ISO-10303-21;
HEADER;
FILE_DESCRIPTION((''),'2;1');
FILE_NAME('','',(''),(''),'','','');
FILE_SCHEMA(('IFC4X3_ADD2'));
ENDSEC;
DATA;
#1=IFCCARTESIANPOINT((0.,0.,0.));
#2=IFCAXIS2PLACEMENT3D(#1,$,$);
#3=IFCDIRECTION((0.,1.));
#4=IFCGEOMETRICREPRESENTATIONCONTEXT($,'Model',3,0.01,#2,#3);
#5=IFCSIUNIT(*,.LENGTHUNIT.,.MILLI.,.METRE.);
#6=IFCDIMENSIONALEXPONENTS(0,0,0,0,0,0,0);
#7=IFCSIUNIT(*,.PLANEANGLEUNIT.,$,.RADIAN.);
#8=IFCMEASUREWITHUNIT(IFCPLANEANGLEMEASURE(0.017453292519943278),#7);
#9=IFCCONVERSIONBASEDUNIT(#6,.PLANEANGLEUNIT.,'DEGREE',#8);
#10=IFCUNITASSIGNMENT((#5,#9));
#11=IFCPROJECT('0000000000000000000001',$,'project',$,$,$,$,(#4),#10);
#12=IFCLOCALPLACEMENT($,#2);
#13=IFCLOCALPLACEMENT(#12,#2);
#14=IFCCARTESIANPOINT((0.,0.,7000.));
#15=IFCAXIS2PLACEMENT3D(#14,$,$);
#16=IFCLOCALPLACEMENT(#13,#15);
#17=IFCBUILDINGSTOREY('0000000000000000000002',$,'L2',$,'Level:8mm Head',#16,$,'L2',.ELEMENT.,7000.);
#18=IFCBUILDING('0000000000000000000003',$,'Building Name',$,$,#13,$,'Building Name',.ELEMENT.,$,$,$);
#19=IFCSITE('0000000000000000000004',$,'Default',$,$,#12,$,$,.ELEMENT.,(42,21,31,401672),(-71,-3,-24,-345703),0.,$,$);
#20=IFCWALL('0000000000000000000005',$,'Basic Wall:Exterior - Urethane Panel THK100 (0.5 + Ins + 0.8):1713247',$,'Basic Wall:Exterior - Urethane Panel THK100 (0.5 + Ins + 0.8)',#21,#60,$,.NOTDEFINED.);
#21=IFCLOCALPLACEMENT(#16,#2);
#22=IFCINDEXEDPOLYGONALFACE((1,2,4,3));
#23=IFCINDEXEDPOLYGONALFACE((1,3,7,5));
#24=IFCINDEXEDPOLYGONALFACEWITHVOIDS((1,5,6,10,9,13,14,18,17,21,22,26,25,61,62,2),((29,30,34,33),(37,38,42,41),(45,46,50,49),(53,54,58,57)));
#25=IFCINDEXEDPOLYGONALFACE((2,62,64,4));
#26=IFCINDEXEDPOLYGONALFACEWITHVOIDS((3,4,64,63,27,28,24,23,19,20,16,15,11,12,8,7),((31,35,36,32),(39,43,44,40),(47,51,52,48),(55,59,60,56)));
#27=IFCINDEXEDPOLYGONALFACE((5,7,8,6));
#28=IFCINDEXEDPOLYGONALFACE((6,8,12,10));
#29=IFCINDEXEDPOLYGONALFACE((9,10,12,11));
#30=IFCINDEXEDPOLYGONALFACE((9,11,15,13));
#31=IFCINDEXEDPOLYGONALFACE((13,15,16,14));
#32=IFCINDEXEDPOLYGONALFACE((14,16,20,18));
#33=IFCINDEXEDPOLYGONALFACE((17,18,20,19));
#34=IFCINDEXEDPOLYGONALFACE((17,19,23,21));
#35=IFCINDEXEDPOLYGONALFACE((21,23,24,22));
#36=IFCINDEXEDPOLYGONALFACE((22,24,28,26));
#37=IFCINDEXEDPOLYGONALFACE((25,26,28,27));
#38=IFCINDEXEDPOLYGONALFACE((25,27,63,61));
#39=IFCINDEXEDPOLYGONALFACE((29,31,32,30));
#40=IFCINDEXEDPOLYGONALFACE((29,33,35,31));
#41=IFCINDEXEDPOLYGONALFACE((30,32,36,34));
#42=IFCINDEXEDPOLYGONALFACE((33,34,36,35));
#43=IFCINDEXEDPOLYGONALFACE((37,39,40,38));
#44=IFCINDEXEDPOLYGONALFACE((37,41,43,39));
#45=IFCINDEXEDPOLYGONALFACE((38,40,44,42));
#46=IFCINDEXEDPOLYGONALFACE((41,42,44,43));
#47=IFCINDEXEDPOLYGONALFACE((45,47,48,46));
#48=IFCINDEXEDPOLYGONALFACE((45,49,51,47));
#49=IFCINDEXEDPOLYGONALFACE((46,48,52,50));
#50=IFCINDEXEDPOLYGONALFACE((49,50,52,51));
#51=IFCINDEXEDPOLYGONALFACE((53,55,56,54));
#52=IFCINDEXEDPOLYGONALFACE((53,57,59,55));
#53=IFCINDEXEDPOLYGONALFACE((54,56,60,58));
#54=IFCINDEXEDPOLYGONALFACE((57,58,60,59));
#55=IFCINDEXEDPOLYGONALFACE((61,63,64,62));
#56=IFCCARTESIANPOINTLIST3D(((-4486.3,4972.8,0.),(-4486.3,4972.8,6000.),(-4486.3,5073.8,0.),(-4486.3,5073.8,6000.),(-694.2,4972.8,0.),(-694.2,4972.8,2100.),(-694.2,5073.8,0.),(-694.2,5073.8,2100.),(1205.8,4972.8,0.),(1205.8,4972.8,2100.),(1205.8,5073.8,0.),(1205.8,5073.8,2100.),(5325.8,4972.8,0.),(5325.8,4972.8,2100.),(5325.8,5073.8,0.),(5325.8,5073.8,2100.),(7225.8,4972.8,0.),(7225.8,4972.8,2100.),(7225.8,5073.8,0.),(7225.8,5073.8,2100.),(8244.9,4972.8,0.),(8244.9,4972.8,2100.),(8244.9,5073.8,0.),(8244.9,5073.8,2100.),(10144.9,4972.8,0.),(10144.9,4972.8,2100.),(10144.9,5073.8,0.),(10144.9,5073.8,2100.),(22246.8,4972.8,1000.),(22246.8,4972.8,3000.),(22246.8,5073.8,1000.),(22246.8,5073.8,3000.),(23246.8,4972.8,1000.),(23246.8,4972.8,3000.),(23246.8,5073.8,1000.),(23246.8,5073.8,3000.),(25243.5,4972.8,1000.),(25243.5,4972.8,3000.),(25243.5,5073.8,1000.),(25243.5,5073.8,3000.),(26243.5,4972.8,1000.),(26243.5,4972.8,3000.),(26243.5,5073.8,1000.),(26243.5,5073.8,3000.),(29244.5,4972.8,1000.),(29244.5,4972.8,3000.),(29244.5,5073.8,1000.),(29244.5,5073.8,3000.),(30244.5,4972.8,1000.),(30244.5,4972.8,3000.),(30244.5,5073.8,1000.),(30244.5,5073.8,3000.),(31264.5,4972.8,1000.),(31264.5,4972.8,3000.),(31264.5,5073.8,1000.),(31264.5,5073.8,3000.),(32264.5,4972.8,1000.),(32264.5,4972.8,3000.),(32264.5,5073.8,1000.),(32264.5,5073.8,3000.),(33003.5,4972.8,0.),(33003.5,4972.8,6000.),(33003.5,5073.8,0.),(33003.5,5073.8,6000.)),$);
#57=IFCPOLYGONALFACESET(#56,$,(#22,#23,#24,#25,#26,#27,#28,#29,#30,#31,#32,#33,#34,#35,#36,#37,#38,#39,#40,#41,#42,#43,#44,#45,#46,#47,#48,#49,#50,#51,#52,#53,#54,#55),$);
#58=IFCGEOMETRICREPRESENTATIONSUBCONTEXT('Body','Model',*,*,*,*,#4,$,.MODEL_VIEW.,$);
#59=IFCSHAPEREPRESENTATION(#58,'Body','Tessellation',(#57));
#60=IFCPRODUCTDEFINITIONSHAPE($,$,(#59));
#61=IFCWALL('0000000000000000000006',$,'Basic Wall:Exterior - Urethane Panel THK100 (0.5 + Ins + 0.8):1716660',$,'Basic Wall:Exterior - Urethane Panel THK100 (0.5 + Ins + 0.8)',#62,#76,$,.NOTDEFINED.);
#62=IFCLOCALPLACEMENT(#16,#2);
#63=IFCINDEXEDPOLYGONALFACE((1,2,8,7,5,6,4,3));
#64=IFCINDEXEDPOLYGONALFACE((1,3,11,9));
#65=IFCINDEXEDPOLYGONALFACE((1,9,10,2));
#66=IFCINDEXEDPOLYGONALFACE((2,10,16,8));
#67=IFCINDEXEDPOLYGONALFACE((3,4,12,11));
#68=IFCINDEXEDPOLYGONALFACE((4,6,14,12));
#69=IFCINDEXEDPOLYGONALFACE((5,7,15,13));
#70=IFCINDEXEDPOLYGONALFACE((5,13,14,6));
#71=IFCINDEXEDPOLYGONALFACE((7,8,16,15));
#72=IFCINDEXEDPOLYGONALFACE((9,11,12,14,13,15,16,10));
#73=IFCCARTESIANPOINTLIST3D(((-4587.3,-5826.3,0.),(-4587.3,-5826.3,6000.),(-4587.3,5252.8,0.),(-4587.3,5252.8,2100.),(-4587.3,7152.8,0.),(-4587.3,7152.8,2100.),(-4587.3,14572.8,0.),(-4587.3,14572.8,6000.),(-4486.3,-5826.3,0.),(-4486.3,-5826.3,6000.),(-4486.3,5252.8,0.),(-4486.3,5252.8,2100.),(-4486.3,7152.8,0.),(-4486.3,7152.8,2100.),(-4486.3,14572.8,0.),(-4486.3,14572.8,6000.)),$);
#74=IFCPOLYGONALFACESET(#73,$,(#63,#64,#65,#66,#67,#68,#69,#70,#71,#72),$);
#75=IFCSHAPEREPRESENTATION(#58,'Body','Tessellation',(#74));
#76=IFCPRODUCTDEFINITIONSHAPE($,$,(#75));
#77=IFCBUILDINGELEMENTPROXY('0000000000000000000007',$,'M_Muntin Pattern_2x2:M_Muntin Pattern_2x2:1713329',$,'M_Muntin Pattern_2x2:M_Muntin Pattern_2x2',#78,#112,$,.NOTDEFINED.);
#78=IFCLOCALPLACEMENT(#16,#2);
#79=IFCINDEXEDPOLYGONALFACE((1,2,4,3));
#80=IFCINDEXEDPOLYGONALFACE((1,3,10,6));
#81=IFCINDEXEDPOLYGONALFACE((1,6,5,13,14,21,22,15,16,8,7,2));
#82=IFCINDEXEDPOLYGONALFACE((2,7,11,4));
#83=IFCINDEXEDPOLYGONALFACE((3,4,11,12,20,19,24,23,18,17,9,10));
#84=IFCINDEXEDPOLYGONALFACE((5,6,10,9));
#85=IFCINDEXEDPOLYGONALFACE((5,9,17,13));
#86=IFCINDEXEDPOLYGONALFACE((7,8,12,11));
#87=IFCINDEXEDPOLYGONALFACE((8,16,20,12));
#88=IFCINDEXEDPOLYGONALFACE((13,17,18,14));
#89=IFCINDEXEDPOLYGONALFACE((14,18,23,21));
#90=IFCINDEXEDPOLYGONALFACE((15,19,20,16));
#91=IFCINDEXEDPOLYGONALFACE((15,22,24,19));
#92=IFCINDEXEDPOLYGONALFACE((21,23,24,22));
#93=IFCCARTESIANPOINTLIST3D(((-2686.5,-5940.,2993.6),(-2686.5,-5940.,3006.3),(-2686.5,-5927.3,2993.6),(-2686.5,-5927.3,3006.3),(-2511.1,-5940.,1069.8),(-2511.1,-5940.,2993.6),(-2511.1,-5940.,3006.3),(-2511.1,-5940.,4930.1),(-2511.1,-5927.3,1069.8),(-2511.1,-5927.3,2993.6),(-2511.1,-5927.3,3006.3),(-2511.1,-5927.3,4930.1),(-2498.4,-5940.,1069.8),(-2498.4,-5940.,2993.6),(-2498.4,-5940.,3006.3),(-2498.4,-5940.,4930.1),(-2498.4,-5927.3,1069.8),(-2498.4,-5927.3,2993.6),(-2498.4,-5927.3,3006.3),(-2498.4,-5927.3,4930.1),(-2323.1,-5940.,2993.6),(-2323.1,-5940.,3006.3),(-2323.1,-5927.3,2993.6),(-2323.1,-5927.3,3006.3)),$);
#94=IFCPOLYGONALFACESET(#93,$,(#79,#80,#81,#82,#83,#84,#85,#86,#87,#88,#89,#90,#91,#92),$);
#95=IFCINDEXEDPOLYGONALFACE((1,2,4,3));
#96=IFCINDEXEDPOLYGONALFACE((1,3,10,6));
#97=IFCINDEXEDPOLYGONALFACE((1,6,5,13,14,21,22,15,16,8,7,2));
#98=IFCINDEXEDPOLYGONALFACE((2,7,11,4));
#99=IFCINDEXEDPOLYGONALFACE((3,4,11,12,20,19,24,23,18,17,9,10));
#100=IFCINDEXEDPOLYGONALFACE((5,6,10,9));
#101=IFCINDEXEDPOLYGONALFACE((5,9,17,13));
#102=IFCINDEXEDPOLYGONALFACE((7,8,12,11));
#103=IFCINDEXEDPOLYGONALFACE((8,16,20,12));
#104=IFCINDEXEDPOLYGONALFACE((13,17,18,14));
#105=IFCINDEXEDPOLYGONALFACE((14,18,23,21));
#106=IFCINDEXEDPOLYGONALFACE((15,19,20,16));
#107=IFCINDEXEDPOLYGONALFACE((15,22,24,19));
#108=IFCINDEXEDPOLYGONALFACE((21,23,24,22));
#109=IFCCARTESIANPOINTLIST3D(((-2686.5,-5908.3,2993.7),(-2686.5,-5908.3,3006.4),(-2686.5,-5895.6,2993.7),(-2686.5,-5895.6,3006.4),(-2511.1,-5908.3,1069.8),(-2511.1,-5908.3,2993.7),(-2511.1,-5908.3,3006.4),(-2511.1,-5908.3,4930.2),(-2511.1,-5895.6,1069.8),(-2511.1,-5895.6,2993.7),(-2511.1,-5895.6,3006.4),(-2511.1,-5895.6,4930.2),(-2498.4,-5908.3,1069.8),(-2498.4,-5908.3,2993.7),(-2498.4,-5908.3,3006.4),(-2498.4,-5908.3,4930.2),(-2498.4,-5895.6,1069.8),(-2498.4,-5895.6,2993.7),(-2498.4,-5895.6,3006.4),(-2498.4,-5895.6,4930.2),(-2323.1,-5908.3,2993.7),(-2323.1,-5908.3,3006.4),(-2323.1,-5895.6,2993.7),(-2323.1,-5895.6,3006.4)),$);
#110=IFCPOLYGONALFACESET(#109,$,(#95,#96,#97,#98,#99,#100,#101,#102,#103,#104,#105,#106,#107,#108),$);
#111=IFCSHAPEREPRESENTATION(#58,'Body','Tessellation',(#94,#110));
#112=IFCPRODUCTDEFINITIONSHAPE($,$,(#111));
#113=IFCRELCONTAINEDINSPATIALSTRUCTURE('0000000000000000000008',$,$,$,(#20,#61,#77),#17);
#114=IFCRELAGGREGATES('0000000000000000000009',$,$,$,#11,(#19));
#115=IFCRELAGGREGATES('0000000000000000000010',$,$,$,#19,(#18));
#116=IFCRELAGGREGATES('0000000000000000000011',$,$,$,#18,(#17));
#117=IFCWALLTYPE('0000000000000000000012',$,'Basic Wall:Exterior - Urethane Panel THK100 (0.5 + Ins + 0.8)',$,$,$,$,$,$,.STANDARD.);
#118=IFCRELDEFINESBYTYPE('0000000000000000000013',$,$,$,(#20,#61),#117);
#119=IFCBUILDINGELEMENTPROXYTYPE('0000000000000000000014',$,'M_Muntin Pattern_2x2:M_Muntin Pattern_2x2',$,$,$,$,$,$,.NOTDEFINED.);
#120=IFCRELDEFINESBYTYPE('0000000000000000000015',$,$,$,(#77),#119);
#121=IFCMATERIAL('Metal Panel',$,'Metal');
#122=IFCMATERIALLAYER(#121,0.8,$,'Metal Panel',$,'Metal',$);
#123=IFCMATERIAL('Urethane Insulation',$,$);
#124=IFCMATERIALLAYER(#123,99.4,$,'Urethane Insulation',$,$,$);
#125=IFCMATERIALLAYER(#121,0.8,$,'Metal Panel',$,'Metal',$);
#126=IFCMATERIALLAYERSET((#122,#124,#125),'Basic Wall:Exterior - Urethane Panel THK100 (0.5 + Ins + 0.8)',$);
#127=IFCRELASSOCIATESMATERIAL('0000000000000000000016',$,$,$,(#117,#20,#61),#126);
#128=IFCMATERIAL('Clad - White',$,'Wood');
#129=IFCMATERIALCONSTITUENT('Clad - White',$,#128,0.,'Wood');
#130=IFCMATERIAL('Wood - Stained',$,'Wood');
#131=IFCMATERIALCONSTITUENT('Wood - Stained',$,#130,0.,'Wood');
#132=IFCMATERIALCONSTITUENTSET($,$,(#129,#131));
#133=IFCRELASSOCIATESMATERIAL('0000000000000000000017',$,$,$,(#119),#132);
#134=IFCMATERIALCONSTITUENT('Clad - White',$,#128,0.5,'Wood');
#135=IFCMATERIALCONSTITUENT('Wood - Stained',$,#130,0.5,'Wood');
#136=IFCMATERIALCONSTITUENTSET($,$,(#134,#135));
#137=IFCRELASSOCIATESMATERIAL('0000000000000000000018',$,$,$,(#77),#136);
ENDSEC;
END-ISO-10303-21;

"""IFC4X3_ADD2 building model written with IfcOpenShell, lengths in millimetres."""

from ifc_helpers import new_model, entity, si_unit, converted_unit, direction, frame, frame_2d, origin, place, context, subcontext, project, spatial, polyline, rectangle, outline, extrude, source, transform, mapped, material, layer, layer_set, constituent, constituent_set, type_object, type_shapes, element, save


model = new_model("IFC4X3_ADD2")

# Units and contexts
model_context = context("Model", 3, precision=0.01, world=origin(), true_north=direction((0.0, 1.0)))
body_context = subcontext(model_context, "Body", "Model", "MODEL_VIEW")
ifc_project = project(units=[si_unit("LENGTHUNIT", "METRE", prefix="MILLI"), converted_unit("PLANEANGLEUNIT", "DEGREE", entity("IfcPlaneAngleMeasure", 0.017453292519943278), si_unit("PLANEANGLEUNIT", "RADIAN"), dimensions=[0, 0, 0, 0, 0, 0, 0])], contexts=[model_context])

# Site, building, storey
site_placement = place(None, origin())
site = spatial("IfcSite", under=ifc_project, at=site_placement, Name="Default", CompositionType="ELEMENT", RefLatitude=(42, 21, 31, 401672), RefLongitude=(-71, -3, -24, -345703), RefElevation=0.0)
building_placement = place(site_placement, origin())
building = spatial("IfcBuilding", under=site, at=building_placement, Name="Building Name", LongName="Building Name", CompositionType="ELEMENT")
storey_placement = place(building_placement, frame((0.0, 0.0, 7000.0)))
storey = spatial("IfcBuildingStorey", under=building, at=storey_placement, Name="L2", ObjectType="Level:8mm Head", LongName="L2", CompositionType="ELEMENT", Elevation=7000.0)

# Wall, openings
ifc_material_1 = material(Name="Metal Panel", Category="Metal")
ifc_layer_1 = layer(ifc_material_1, 0.8, Name="Metal Panel", Category="Metal")
ifc_material_2 = material(Name="Urethane Insulation")
ifc_layer_2 = layer(ifc_material_2, 99.4, Name="Urethane Insulation")
ifc_layer_3 = layer(ifc_material_1, 0.8, Name="Metal Panel", Category="Metal")
ifc_layer_set = layer_set([ifc_layer_1, ifc_layer_2, ifc_layer_3], Name="Basic Wall:Exterior - Urethane Panel THK100 (0.5 + Ins + 0.8)")
wall_type = type_object("IfcWallType", Name="Basic Wall:Exterior - Urethane Panel THK100 (0.5 + Ins + 0.8)", PredefinedType="STANDARD", material=ifc_layer_set)
wall_1_placement = place(storey_placement, frame((-4486.3, 5023.3, 0.0)))
wall_1 = element("IfcWall", 1, at=wall_1_placement, inside=storey, type_object=wall_type, material=ifc_layer_set, Name="Basic Wall:Exterior - Urethane Panel THK100 (0.5 + Ins + 0.8):1713247", ObjectType="Basic Wall:Exterior - Urethane Panel THK100 (0.5 + Ins + 0.8)", PredefinedType="NOTDEFINED", context=body_context, shape_type="SweptSolid", body=[
    extrude(rectangle(XDim=37489.9, YDim=101.0, at=frame_2d((18744.9, 0.0), x_axis=(-1.0, 0.0))), origin(), (0.0, 0.0, 1.0), 6000.0),
])
opening_1_placement = place(wall_1_placement, frame((5692.1, 50.5, 0.0)))
element("IfcOpeningElement", 2, at=opening_1_placement, cuts=wall_1, PredefinedType="OPENING", context=body_context, shape_type="SweptSolid", body=[
    extrude(rectangle(XDim=2100.0, YDim=1900.0, at=frame_2d((1050.0, 950.0), x_axis=(1.0, 0.0))), frame((0.0, 0.0, 0.0), z_axis=(0.0, -1.0, 0.0), x_axis=(0.0, 0.0, 1.0)), (0.0, 0.0, 1.0), 101.0),
])
opening_2_placement = place(wall_1_placement, frame((11712.2, 50.5, 0.0)))
element("IfcOpeningElement", 3, at=opening_2_placement, cuts=wall_1, PredefinedType="OPENING", context=body_context, shape_type="SweptSolid", body=[
    extrude(rectangle(XDim=2100.0, YDim=1900.0, at=frame_2d((1050.0, 950.0), x_axis=(1.0, 0.0))), frame((0.0, 0.0, 0.0), z_axis=(0.0, -1.0, 0.0), x_axis=(0.0, 0.0, 1.0)), (0.0, 0.0, 1.0), 101.0),
])
opening_3_placement = place(wall_1_placement, frame((14631.2, 50.5, 0.0)))
element("IfcOpeningElement", 4, at=opening_3_placement, cuts=wall_1, PredefinedType="OPENING", context=body_context, shape_type="SweptSolid", body=[
    extrude(rectangle(XDim=2100.0, YDim=1900.0, at=frame_2d((1050.0, 950.0), x_axis=(1.0, 0.0))), frame((0.0, 0.0, 0.0), z_axis=(0.0, -1.0, 0.0), x_axis=(0.0, 0.0, 1.0)), (0.0, 0.0, 1.0), 101.0),
])
opening_4_placement = place(wall_1_placement, frame((27733.1, 50.5, 1000.0)))
element("IfcOpeningElement", 5, at=opening_4_placement, cuts=wall_1, PredefinedType="OPENING", context=body_context, shape_type="SweptSolid", body=[
    extrude(rectangle(XDim=2000.0, YDim=1000.0, at=frame_2d((1000.0, 500.0), x_axis=(-1.0, 0.0))), frame((0.0, 0.0, 0.0), z_axis=(0.0, -1.0, 0.0), x_axis=(0.0, 0.0, 1.0)), (0.0, 0.0, 1.0), 101.0),
])
opening_5_placement = place(wall_1_placement, frame((30729.9, 50.5, 1000.0)))
element("IfcOpeningElement", 6, at=opening_5_placement, cuts=wall_1, PredefinedType="OPENING", context=body_context, shape_type="SweptSolid", body=[
    extrude(rectangle(XDim=2000.0, YDim=1000.0, at=frame_2d((1000.0, 500.0), x_axis=(-1.0, 0.0))), frame((0.0, 0.0, 0.0), z_axis=(0.0, -1.0, 0.0), x_axis=(0.0, 0.0, 1.0)), (0.0, 0.0, 1.0), 101.0),
])
opening_6_placement = place(wall_1_placement, frame((34730.9, 50.5, 1000.0)))
element("IfcOpeningElement", 7, at=opening_6_placement, cuts=wall_1, PredefinedType="OPENING", context=body_context, shape_type="SweptSolid", body=[
    extrude(rectangle(XDim=2000.0, YDim=1000.0, at=frame_2d((1000.0, 500.0), x_axis=(-1.0, 0.0))), frame((0.0, 0.0, 0.0), z_axis=(0.0, -1.0, 0.0), x_axis=(0.0, 0.0, 1.0)), (0.0, 0.0, 1.0), 101.0),
])
opening_7_placement = place(wall_1_placement, frame((36750.9, 50.5, 1000.0)))
element("IfcOpeningElement", 8, at=opening_7_placement, cuts=wall_1, PredefinedType="OPENING", context=body_context, shape_type="SweptSolid", body=[
    extrude(rectangle(XDim=2000.0, YDim=1000.0, at=frame_2d((1000.0, 500.0), x_axis=(-1.0, 0.0))), frame((0.0, 0.0, 0.0), z_axis=(0.0, -1.0, 0.0), x_axis=(0.0, 0.0, 1.0)), (0.0, 0.0, 1.0), 101.0),
])

# Wall, opening
wall_2_placement = place(storey_placement, frame((-4536.8, -5826.3, 0.0), z_axis=(0.0, 0.0, 1.0), x_axis=(0.0, 1.0, 0.0)))
wall_2 = element("IfcWall", 9, at=wall_2_placement, inside=storey, type_object=wall_type, material=ifc_layer_set, Name="Basic Wall:Exterior - Urethane Panel THK100 (0.5 + Ins + 0.8):1716660", ObjectType="Basic Wall:Exterior - Urethane Panel THK100 (0.5 + Ins + 0.8)", PredefinedType="NOTDEFINED", context=body_context, shape_type="SweptSolid", body=[
    extrude(rectangle(XDim=20399.1, YDim=101.0, at=frame_2d((10199.5, 0.0), x_axis=(-1.0, 0.0))), origin(), (0.0, 0.0, 1.0), 6000.0),
])
opening_8_placement = place(wall_2_placement, frame((12979.1, 50.5, 0.0)))
element("IfcOpeningElement", 10, at=opening_8_placement, cuts=wall_2, PredefinedType="OPENING", context=body_context, shape_type="SweptSolid", body=[
    extrude(rectangle(XDim=2100.0, YDim=1900.0, at=frame_2d((1050.0, 950.0), x_axis=(1.0, 0.0))), frame((0.0, 0.0, 0.0), z_axis=(0.0, -1.0, 0.0), x_axis=(0.0, 0.0, 1.0)), (0.0, 0.0, 1.0), 101.0),
])

# Building element proxy
ifc_material_3 = material(Name="Clad - White", Category="Wood")
ifc_constituent_1 = constituent(ifc_material_3, Name="Clad - White", Category="Wood", fraction=0.5)
ifc_material_4 = material(Name="Wood - Stained", Category="Wood")
ifc_constituent_2 = constituent(ifc_material_4, Name="Wood - Stained", Category="Wood", fraction=0.5)
ifc_constituent_set_1 = constituent_set(constituents=[ifc_constituent_1, ifc_constituent_2])
ifc_constituent_3 = constituent(ifc_material_3, Name="Clad - White", Category="Wood", fraction=0.0)
ifc_constituent_4 = constituent(ifc_material_4, Name="Wood - Stained", Category="Wood", fraction=0.0)
ifc_constituent_set_2 = constituent_set(constituents=[ifc_constituent_3, ifc_constituent_4])
building_element_proxy_type_1 = type_object("IfcBuildingElementProxyType", Name="M_Muntin Pattern_2x2:M_Muntin Pattern_2x2", PredefinedType="NOTDEFINED", material=ifc_constituent_set_2)
shared_shape_1 = source(origin(), body_context, "Body", "SweptSolid", [
    extrude(outline(polyline([(6.4, -6.4), (1930.1, -6.4), (1930.1, 6.3), (6.4, 6.3), (6.4, 181.7), (-6.3, 181.7), (-6.3, 6.3), (-1930.2, 6.3), (-1930.2, -6.4), (-6.3, -6.4), (-6.3, -181.7), (6.4, -181.7), (6.4, -6.4)])), frame((0.0, 9.5, 1930.1), z_axis=(0.0, 1.0, 0.0), x_axis=(0.0, 0.0, 1.0)), (0.0, 0.0, 1.0), 12.7),
    extrude(outline(polyline([(6.4, -6.4), (1930.2, -6.4), (1930.2, 6.3), (6.4, 6.3), (6.4, 181.7), (-6.3, 181.7), (-6.3, 6.3), (-1930.2, 6.3), (-1930.2, -6.4), (-6.3, -6.4), (-6.3, -181.7), (6.4, -181.7), (6.4, -6.4)])), frame((0.0, -22.2, 1930.2), z_axis=(0.0, 1.0, 0.0), x_axis=(0.0, 0.0, 1.0)), (0.0, 0.0, 1.0), 12.7),
])
type_shapes(building_element_proxy_type_1, [shared_shape_1])
proxy_1_placement = place(storey_placement, frame((-2504.8, -5917.8, 1069.8), z_axis=(0.0, 0.0, 1.0), x_axis=(-1.0, 0.0, 0.0)))
element("IfcBuildingElementProxy", 11, at=proxy_1_placement, inside=storey, type_object=building_element_proxy_type_1, material=ifc_constituent_set_1, Name="M_Muntin Pattern_2x2:M_Muntin Pattern_2x2:1713329", ObjectType="M_Muntin Pattern_2x2:M_Muntin Pattern_2x2", PredefinedType="NOTDEFINED", context=body_context, shape_type="MappedRepresentation", body=[
    mapped(shared_shape_1, transform((0.0, 0.0, 0.0), scale=1.0)),
])

save(model, "model.ifc")
